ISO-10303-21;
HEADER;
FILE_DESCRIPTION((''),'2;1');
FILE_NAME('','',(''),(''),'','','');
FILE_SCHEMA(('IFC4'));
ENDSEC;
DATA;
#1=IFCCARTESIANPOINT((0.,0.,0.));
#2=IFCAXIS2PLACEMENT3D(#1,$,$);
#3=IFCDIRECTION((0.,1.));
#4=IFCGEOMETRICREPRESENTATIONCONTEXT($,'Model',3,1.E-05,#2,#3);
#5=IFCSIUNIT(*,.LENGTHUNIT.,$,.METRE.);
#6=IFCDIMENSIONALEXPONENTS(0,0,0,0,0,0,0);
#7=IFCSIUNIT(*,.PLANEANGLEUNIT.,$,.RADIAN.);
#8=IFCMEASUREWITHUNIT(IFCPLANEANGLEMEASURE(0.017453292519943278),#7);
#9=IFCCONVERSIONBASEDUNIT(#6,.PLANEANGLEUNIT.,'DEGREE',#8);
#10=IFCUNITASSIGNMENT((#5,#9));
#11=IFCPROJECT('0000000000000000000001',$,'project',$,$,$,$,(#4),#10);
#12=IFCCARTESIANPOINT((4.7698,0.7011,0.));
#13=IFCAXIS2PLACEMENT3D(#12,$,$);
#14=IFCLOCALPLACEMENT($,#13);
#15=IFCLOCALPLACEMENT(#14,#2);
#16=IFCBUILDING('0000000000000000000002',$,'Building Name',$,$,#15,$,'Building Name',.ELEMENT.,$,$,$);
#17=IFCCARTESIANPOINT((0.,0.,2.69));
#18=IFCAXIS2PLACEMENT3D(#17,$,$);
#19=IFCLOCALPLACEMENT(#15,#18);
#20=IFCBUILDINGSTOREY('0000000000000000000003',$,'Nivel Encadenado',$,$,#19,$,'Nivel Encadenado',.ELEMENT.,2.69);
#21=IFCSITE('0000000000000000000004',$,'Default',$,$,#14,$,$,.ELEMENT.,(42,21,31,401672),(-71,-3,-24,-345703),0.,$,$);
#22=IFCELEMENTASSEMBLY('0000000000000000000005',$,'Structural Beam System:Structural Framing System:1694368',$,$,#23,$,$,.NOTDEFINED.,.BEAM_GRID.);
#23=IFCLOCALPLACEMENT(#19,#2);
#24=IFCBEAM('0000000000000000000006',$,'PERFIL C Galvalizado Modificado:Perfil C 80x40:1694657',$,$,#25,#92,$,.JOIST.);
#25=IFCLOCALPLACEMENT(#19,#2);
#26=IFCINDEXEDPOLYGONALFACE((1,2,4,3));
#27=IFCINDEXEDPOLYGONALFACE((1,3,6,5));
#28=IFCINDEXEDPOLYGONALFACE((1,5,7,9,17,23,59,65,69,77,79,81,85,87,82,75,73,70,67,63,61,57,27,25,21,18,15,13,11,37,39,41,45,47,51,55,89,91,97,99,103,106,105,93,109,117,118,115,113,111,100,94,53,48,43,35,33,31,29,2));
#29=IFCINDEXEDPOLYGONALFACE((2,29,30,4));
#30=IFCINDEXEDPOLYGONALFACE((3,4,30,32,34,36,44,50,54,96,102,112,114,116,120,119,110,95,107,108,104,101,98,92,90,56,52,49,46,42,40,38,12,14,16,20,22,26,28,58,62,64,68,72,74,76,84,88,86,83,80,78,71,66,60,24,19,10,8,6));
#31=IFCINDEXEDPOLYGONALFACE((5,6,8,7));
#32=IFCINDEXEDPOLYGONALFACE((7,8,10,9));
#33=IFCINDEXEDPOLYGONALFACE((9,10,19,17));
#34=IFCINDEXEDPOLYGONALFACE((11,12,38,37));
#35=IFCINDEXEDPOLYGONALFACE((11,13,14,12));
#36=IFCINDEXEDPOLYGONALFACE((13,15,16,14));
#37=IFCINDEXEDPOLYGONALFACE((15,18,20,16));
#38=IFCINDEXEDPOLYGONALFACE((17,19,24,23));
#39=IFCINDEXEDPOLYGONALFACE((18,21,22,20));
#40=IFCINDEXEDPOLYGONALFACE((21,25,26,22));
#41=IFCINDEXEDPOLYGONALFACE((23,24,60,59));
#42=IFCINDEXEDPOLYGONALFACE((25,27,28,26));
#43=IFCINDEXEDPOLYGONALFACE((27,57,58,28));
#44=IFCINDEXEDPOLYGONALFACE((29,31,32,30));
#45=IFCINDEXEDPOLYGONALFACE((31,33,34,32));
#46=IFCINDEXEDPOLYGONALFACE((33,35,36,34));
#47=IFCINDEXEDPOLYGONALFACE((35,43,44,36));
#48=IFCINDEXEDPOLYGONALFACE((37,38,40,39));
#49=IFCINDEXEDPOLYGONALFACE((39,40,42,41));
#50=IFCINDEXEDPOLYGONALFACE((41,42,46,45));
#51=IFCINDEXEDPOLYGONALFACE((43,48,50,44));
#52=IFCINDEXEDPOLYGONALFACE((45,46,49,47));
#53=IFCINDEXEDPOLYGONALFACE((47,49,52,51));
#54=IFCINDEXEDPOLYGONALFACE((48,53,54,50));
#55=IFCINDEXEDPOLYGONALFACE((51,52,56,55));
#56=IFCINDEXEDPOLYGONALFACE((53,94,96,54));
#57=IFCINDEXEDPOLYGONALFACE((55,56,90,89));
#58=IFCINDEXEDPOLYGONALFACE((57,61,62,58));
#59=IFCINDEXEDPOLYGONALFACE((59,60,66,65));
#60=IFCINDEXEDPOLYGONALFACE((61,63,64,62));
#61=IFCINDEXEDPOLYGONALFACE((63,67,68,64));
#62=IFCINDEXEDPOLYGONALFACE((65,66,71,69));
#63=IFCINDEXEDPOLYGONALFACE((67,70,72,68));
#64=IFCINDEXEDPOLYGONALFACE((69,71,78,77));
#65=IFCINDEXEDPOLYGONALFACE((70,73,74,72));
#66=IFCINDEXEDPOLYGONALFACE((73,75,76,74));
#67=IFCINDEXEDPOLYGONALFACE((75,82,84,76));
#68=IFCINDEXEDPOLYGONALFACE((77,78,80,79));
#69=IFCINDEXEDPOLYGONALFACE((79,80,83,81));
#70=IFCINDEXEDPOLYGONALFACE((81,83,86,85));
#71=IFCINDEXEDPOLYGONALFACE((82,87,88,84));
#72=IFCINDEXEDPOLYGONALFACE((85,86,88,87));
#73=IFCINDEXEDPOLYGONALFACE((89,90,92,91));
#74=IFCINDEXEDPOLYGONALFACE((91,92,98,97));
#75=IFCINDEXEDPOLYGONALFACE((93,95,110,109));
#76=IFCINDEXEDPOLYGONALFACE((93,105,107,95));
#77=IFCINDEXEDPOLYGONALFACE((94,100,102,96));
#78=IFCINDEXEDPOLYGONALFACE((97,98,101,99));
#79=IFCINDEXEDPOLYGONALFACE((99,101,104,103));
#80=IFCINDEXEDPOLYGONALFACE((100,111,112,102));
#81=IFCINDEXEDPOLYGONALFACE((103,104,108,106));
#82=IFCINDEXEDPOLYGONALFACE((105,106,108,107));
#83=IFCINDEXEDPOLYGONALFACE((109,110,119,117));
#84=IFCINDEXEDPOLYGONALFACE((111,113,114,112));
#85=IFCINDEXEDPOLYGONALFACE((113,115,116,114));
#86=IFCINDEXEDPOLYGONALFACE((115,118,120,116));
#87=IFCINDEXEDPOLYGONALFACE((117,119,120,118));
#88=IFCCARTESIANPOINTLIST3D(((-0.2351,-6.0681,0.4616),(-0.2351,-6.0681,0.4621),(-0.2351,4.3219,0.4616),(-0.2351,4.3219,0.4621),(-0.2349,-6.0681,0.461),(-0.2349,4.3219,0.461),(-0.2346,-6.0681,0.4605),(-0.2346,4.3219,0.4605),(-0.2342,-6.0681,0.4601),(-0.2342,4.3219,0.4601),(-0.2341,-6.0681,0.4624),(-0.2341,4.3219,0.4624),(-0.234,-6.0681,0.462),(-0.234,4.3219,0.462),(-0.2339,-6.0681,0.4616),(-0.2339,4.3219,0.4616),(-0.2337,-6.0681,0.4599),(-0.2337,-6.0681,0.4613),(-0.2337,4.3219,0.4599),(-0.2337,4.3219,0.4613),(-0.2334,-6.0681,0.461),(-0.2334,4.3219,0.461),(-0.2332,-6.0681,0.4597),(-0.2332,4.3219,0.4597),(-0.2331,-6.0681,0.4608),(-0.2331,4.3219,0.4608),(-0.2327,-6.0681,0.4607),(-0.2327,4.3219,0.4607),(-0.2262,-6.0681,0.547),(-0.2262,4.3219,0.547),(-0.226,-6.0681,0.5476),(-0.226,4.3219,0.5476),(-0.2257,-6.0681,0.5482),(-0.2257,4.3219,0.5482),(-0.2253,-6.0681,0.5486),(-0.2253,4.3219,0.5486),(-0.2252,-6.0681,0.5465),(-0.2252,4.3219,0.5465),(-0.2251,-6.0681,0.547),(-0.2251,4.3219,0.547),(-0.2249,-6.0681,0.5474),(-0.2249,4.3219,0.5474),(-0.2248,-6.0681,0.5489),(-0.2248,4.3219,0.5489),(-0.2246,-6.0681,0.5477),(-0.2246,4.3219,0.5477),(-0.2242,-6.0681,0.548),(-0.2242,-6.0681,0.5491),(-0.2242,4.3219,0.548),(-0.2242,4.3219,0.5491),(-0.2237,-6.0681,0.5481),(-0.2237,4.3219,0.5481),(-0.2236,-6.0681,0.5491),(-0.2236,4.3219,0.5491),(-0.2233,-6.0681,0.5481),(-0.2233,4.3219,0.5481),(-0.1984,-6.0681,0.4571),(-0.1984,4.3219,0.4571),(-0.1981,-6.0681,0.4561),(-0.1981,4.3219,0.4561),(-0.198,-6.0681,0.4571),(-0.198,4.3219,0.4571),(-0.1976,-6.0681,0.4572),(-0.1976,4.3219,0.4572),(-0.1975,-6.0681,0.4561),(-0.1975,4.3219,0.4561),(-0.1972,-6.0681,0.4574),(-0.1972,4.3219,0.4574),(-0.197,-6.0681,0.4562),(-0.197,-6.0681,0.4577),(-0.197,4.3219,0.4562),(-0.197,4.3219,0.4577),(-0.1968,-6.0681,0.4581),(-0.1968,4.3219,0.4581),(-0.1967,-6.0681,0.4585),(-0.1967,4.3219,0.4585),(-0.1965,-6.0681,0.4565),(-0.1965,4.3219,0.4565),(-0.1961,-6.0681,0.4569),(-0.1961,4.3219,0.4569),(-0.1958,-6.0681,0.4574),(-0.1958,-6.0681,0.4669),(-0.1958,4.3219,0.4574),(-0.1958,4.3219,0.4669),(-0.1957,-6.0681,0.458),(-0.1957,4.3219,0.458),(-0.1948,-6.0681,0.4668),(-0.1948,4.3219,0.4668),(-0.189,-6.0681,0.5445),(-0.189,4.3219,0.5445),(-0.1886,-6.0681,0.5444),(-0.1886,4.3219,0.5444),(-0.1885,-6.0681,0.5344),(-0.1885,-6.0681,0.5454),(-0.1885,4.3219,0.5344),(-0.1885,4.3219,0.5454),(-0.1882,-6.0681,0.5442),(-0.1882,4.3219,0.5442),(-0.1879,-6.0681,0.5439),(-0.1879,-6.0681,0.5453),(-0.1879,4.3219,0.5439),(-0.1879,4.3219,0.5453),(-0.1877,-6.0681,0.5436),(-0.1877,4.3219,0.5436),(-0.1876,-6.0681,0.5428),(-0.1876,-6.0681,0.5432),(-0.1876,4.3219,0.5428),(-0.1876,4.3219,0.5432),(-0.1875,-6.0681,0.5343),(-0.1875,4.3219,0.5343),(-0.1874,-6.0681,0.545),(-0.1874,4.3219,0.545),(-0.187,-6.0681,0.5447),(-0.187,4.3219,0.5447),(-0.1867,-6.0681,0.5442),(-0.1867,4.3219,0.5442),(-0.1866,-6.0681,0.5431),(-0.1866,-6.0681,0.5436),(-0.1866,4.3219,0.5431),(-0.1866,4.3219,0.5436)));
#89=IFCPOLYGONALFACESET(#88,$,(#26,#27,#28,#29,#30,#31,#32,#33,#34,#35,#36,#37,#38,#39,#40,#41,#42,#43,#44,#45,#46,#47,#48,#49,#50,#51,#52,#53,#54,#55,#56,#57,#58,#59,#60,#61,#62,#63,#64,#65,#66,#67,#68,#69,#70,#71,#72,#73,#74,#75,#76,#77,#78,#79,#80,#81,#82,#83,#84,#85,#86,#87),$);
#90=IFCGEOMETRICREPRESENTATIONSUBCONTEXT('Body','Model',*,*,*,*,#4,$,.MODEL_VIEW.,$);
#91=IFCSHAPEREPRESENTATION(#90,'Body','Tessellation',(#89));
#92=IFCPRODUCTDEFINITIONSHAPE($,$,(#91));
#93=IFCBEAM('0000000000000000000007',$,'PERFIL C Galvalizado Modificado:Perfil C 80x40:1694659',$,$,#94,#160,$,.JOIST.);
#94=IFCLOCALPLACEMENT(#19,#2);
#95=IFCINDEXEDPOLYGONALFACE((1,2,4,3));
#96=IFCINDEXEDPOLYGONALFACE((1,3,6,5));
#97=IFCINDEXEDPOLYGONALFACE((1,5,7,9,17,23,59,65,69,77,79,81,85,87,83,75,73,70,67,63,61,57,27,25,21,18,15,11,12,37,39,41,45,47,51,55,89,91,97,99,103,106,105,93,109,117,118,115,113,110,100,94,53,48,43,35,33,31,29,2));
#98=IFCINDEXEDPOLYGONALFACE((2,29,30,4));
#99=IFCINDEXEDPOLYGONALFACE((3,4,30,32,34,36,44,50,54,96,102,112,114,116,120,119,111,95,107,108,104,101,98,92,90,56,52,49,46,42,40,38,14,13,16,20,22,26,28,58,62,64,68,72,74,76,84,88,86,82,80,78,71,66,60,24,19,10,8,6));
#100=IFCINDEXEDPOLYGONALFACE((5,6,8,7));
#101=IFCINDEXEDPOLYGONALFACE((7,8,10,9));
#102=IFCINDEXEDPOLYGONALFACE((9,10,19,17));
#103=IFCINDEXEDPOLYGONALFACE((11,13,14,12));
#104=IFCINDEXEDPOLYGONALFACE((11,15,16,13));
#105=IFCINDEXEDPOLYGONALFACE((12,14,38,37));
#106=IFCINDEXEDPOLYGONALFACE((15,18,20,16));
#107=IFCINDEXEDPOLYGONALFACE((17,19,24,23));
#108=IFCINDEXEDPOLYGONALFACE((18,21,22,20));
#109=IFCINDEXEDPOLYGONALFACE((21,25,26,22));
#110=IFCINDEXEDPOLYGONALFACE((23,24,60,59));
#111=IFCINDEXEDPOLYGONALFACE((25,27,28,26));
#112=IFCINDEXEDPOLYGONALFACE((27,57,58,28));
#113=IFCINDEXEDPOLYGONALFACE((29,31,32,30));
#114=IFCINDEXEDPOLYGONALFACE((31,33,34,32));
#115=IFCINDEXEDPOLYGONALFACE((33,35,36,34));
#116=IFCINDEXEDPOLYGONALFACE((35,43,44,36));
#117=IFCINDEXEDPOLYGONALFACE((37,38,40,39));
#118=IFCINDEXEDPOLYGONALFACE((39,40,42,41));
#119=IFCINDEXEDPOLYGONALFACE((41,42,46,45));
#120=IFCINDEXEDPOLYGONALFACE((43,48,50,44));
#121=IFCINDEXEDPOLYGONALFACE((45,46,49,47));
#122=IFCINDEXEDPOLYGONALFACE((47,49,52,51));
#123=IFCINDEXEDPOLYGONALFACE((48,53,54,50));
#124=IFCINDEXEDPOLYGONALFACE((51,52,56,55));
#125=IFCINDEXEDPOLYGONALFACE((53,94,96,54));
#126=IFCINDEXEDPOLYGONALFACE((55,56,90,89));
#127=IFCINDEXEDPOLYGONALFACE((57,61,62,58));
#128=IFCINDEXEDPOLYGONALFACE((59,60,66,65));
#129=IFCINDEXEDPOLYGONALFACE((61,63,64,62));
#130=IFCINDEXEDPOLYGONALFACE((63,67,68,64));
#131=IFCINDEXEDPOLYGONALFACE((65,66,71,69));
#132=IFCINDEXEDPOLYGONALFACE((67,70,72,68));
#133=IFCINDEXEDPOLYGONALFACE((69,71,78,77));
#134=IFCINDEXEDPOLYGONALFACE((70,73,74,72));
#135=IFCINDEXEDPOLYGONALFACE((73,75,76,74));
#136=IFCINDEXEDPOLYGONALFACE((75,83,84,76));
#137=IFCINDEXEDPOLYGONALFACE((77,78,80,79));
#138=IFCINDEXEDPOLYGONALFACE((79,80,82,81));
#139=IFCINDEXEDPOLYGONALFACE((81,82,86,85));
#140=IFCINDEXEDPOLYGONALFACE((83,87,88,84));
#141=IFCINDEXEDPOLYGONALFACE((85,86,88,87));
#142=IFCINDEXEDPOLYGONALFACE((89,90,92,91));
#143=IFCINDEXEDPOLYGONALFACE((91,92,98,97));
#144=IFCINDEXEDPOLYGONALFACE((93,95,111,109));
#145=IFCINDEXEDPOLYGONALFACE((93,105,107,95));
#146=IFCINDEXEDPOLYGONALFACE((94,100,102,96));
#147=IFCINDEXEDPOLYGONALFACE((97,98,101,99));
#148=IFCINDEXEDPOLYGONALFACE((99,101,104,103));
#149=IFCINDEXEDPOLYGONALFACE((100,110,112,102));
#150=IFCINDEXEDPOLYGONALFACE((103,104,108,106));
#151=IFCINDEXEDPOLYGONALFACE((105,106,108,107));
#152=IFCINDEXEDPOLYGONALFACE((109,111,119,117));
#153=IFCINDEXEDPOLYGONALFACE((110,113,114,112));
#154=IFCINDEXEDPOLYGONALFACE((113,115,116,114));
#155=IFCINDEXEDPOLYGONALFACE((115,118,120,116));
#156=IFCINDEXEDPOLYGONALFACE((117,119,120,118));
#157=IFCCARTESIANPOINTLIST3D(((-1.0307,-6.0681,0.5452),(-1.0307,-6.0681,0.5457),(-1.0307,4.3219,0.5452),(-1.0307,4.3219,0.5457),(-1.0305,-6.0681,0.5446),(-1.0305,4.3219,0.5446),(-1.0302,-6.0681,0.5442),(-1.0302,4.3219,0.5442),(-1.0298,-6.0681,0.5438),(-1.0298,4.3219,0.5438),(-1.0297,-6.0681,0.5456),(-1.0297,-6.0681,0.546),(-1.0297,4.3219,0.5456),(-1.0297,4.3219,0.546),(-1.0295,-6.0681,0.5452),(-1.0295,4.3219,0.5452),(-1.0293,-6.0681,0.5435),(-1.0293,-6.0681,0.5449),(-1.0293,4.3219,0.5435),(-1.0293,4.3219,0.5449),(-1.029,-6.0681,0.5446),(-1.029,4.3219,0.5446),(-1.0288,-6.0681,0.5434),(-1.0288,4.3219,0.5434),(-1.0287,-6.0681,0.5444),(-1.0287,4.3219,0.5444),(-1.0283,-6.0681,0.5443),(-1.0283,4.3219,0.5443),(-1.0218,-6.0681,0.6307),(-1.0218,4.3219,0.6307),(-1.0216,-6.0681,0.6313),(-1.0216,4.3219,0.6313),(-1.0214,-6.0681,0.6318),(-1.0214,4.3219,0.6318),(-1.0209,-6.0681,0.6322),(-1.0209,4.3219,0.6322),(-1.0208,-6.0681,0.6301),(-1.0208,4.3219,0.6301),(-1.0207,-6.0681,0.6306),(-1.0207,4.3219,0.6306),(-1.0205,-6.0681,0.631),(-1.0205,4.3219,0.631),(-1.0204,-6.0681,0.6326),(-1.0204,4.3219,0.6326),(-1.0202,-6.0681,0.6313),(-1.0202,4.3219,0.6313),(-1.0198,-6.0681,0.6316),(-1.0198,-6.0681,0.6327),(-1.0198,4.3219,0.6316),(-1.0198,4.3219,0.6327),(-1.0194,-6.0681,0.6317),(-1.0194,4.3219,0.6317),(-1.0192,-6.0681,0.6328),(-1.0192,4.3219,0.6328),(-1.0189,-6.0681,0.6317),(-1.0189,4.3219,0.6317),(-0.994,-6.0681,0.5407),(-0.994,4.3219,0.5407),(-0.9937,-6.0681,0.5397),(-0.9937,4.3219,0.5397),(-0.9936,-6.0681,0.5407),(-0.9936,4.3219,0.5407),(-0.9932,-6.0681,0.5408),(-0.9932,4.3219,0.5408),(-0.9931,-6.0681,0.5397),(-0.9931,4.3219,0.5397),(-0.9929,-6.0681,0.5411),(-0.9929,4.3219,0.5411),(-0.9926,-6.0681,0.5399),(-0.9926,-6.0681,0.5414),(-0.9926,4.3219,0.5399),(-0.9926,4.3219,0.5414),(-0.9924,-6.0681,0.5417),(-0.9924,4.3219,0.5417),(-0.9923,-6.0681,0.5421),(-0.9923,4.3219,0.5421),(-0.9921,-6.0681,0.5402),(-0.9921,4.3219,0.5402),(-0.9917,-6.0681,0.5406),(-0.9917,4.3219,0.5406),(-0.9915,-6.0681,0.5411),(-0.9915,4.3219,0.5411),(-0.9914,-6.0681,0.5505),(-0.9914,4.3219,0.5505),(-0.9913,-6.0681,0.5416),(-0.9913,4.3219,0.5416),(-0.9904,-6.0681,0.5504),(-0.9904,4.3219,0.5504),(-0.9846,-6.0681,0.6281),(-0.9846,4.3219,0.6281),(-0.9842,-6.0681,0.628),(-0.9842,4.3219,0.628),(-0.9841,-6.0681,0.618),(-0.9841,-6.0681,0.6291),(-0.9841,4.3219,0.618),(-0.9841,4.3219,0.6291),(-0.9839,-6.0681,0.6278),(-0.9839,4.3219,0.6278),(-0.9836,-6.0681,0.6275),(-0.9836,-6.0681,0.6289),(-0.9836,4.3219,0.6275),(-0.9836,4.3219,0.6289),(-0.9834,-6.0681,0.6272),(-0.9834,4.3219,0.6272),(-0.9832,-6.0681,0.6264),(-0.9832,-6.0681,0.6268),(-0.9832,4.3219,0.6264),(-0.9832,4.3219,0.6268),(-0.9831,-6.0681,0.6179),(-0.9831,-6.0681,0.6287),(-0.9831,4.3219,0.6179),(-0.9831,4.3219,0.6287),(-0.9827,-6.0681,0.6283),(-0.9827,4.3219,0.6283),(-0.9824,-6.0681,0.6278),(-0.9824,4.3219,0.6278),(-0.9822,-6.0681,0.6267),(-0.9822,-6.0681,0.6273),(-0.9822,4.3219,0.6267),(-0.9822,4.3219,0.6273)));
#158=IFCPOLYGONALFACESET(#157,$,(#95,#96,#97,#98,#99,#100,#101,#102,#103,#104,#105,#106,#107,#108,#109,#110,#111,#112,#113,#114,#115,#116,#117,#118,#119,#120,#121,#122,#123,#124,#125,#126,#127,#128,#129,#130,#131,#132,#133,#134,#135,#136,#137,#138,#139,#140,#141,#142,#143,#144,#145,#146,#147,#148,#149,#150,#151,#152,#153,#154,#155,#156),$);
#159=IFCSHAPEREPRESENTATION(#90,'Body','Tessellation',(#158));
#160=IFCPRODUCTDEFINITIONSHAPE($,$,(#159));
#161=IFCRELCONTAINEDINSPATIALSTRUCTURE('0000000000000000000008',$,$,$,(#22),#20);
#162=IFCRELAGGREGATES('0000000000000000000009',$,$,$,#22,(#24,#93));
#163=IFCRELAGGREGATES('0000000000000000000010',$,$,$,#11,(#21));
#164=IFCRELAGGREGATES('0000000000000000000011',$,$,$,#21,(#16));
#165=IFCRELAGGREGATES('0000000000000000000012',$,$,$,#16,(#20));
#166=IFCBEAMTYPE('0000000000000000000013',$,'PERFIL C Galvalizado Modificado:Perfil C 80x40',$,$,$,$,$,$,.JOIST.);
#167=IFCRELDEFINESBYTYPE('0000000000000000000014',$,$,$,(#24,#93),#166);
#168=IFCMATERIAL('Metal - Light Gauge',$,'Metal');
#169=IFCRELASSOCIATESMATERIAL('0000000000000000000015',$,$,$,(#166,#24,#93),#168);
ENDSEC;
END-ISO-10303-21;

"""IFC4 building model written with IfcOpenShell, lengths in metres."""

from ifc_helpers import new_model, entity, si_unit, converted_unit, direction, frame, origin, place, context, subcontext, project, spatial, line, arc, indexed_curve, outline, extrude, source, transform, mapped, material, type_object, type_shapes, element, aggregate, save


model = new_model("IFC4")

# Units and contexts
model_context = context("Model", 3, precision=1e-05, world=origin(), true_north=direction((0.0, 1.0)))
body_context = subcontext(model_context, "Body", "Model", "MODEL_VIEW")
ifc_project = project(units=[si_unit("LENGTHUNIT", "METRE"), converted_unit("PLANEANGLEUNIT", "DEGREE", entity("IfcPlaneAngleMeasure", 0.017453292519943278), si_unit("PLANEANGLEUNIT", "RADIAN"), dimensions=[0, 0, 0, 0, 0, 0, 0])], contexts=[model_context])

# Site, building, storey
site_placement = place(None, frame((4.7698, 0.7011, 0.0)))
site = spatial("IfcSite", under=ifc_project, at=site_placement, Name="Default", CompositionType="ELEMENT", RefLatitude=(42, 21, 31, 401672), RefLongitude=(-71, -3, -24, -345703), RefElevation=0.0)
building_placement = place(site_placement, origin())
building = spatial("IfcBuilding", under=site, at=building_placement, Name="Building Name", LongName="Building Name", CompositionType="ELEMENT")
storey_placement = place(building_placement, frame((0.0, 0.0, 2.69)))
storey = spatial("IfcBuildingStorey", under=building, at=storey_placement, Name="Nivel Encadenado", LongName="Nivel Encadenado", CompositionType="ELEMENT", Elevation=2.69)

# Element assembly, beams
assembly_1_placement = place(storey_placement, origin())
assembly_1 = element("IfcElementAssembly", 1, at=assembly_1_placement, inside=storey, Name="Structural Beam System:Structural Framing System:1694368", AssemblyPlace="NOTDEFINED", PredefinedType="BEAM_GRID")
ifc_material_1 = material(Name="Metal - Light Gauge", Category="Metal")
beam_type_1 = type_object("IfcBeamType", Name="PERFIL C Galvalizado Modificado:Perfil C 80x40", PredefinedType="JOIST", material=ifc_material_1)
shared_shape_1 = source(origin(), body_context, "Body", "SweptSolid", [
    extrude(outline(indexed_curve([(-0.0428, -0.0161), (-0.034, -0.0161), (-0.034, -0.0151), (-0.0424, -0.0151), (-0.0435, -0.0146), (-0.044, -0.0135), (-0.044, 0.021), (-0.0435, 0.0222), (-0.0422, 0.0227), (0.0424, 0.0227), (0.0435, 0.0223), (0.0439, 0.0212), (0.0439, -0.0133), (0.0435, -0.0144), (0.0424, -0.0149), (0.0339, -0.0149), (0.0339, -0.0159), (0.0428, -0.0159), (0.0443, -0.0152), (0.0449, -0.0137), (0.0449, 0.0216), (0.0443, 0.0231), (0.0428, 0.0237), (-0.0426, 0.0237), (-0.0443, 0.023), (-0.045, 0.0214), (-0.045, -0.0139), (-0.0443, -0.0154)], segments=[line(1, 2, 3, 4), arc(4, 5, 6), line(6, 7), arc(7, 8, 9), line(9, 10), arc(10, 11, 12), line(12, 13), arc(13, 14, 15), line(15, 16, 17, 18), arc(18, 19, 20), line(20, 21), arc(21, 22, 23), line(23, 24), arc(24, 25, 26), line(26, 27), arc(27, 28, 1)], self_intersect=False)), frame((-5.195, -0.0037, 0.0), z_axis=(1.0, 0.0, 0.0), x_axis=(0.0, 0.0, -1.0)), (0.0, 0.0, 1.0), 10.39),
])
type_shapes(beam_type_1, [shared_shape_1])
beam_1_placement = place(assembly_1_placement, frame((-0.2107, -0.8731, 0.5026), z_axis=(0.104528, 0.0, 0.994522), x_axis=(0.0, 1.0, 0.0)))
beam_1 = element("IfcBeam", 2, at=beam_1_placement, type_object=beam_type_1, material=ifc_material_1, Name="PERFIL C Galvalizado Modificado:Perfil C 80x40:1694657", PredefinedType="JOIST", context=body_context, shape_type="MappedRepresentation", body=[
    mapped(shared_shape_1, transform((0.0, 0.0, 0.0), scale=1.0)),
])
beam_2_placement = place(assembly_1_placement, frame((-1.0064, -0.8731, 0.5862), z_axis=(0.104528, 0.0, 0.994522), x_axis=(0.0, 1.0, 0.0)))
beam_2 = element("IfcBeam", 3, at=beam_2_placement, type_object=beam_type_1, material=ifc_material_1, Name="PERFIL C Galvalizado Modificado:Perfil C 80x40:1694659", PredefinedType="JOIST", context=body_context, shape_type="MappedRepresentation", body=[
    mapped(shared_shape_1, transform((0.0, 0.0, 0.0), scale=1.0)),
])
aggregate(assembly_1, [beam_1, beam_2])

save(model, "model.ifc")
